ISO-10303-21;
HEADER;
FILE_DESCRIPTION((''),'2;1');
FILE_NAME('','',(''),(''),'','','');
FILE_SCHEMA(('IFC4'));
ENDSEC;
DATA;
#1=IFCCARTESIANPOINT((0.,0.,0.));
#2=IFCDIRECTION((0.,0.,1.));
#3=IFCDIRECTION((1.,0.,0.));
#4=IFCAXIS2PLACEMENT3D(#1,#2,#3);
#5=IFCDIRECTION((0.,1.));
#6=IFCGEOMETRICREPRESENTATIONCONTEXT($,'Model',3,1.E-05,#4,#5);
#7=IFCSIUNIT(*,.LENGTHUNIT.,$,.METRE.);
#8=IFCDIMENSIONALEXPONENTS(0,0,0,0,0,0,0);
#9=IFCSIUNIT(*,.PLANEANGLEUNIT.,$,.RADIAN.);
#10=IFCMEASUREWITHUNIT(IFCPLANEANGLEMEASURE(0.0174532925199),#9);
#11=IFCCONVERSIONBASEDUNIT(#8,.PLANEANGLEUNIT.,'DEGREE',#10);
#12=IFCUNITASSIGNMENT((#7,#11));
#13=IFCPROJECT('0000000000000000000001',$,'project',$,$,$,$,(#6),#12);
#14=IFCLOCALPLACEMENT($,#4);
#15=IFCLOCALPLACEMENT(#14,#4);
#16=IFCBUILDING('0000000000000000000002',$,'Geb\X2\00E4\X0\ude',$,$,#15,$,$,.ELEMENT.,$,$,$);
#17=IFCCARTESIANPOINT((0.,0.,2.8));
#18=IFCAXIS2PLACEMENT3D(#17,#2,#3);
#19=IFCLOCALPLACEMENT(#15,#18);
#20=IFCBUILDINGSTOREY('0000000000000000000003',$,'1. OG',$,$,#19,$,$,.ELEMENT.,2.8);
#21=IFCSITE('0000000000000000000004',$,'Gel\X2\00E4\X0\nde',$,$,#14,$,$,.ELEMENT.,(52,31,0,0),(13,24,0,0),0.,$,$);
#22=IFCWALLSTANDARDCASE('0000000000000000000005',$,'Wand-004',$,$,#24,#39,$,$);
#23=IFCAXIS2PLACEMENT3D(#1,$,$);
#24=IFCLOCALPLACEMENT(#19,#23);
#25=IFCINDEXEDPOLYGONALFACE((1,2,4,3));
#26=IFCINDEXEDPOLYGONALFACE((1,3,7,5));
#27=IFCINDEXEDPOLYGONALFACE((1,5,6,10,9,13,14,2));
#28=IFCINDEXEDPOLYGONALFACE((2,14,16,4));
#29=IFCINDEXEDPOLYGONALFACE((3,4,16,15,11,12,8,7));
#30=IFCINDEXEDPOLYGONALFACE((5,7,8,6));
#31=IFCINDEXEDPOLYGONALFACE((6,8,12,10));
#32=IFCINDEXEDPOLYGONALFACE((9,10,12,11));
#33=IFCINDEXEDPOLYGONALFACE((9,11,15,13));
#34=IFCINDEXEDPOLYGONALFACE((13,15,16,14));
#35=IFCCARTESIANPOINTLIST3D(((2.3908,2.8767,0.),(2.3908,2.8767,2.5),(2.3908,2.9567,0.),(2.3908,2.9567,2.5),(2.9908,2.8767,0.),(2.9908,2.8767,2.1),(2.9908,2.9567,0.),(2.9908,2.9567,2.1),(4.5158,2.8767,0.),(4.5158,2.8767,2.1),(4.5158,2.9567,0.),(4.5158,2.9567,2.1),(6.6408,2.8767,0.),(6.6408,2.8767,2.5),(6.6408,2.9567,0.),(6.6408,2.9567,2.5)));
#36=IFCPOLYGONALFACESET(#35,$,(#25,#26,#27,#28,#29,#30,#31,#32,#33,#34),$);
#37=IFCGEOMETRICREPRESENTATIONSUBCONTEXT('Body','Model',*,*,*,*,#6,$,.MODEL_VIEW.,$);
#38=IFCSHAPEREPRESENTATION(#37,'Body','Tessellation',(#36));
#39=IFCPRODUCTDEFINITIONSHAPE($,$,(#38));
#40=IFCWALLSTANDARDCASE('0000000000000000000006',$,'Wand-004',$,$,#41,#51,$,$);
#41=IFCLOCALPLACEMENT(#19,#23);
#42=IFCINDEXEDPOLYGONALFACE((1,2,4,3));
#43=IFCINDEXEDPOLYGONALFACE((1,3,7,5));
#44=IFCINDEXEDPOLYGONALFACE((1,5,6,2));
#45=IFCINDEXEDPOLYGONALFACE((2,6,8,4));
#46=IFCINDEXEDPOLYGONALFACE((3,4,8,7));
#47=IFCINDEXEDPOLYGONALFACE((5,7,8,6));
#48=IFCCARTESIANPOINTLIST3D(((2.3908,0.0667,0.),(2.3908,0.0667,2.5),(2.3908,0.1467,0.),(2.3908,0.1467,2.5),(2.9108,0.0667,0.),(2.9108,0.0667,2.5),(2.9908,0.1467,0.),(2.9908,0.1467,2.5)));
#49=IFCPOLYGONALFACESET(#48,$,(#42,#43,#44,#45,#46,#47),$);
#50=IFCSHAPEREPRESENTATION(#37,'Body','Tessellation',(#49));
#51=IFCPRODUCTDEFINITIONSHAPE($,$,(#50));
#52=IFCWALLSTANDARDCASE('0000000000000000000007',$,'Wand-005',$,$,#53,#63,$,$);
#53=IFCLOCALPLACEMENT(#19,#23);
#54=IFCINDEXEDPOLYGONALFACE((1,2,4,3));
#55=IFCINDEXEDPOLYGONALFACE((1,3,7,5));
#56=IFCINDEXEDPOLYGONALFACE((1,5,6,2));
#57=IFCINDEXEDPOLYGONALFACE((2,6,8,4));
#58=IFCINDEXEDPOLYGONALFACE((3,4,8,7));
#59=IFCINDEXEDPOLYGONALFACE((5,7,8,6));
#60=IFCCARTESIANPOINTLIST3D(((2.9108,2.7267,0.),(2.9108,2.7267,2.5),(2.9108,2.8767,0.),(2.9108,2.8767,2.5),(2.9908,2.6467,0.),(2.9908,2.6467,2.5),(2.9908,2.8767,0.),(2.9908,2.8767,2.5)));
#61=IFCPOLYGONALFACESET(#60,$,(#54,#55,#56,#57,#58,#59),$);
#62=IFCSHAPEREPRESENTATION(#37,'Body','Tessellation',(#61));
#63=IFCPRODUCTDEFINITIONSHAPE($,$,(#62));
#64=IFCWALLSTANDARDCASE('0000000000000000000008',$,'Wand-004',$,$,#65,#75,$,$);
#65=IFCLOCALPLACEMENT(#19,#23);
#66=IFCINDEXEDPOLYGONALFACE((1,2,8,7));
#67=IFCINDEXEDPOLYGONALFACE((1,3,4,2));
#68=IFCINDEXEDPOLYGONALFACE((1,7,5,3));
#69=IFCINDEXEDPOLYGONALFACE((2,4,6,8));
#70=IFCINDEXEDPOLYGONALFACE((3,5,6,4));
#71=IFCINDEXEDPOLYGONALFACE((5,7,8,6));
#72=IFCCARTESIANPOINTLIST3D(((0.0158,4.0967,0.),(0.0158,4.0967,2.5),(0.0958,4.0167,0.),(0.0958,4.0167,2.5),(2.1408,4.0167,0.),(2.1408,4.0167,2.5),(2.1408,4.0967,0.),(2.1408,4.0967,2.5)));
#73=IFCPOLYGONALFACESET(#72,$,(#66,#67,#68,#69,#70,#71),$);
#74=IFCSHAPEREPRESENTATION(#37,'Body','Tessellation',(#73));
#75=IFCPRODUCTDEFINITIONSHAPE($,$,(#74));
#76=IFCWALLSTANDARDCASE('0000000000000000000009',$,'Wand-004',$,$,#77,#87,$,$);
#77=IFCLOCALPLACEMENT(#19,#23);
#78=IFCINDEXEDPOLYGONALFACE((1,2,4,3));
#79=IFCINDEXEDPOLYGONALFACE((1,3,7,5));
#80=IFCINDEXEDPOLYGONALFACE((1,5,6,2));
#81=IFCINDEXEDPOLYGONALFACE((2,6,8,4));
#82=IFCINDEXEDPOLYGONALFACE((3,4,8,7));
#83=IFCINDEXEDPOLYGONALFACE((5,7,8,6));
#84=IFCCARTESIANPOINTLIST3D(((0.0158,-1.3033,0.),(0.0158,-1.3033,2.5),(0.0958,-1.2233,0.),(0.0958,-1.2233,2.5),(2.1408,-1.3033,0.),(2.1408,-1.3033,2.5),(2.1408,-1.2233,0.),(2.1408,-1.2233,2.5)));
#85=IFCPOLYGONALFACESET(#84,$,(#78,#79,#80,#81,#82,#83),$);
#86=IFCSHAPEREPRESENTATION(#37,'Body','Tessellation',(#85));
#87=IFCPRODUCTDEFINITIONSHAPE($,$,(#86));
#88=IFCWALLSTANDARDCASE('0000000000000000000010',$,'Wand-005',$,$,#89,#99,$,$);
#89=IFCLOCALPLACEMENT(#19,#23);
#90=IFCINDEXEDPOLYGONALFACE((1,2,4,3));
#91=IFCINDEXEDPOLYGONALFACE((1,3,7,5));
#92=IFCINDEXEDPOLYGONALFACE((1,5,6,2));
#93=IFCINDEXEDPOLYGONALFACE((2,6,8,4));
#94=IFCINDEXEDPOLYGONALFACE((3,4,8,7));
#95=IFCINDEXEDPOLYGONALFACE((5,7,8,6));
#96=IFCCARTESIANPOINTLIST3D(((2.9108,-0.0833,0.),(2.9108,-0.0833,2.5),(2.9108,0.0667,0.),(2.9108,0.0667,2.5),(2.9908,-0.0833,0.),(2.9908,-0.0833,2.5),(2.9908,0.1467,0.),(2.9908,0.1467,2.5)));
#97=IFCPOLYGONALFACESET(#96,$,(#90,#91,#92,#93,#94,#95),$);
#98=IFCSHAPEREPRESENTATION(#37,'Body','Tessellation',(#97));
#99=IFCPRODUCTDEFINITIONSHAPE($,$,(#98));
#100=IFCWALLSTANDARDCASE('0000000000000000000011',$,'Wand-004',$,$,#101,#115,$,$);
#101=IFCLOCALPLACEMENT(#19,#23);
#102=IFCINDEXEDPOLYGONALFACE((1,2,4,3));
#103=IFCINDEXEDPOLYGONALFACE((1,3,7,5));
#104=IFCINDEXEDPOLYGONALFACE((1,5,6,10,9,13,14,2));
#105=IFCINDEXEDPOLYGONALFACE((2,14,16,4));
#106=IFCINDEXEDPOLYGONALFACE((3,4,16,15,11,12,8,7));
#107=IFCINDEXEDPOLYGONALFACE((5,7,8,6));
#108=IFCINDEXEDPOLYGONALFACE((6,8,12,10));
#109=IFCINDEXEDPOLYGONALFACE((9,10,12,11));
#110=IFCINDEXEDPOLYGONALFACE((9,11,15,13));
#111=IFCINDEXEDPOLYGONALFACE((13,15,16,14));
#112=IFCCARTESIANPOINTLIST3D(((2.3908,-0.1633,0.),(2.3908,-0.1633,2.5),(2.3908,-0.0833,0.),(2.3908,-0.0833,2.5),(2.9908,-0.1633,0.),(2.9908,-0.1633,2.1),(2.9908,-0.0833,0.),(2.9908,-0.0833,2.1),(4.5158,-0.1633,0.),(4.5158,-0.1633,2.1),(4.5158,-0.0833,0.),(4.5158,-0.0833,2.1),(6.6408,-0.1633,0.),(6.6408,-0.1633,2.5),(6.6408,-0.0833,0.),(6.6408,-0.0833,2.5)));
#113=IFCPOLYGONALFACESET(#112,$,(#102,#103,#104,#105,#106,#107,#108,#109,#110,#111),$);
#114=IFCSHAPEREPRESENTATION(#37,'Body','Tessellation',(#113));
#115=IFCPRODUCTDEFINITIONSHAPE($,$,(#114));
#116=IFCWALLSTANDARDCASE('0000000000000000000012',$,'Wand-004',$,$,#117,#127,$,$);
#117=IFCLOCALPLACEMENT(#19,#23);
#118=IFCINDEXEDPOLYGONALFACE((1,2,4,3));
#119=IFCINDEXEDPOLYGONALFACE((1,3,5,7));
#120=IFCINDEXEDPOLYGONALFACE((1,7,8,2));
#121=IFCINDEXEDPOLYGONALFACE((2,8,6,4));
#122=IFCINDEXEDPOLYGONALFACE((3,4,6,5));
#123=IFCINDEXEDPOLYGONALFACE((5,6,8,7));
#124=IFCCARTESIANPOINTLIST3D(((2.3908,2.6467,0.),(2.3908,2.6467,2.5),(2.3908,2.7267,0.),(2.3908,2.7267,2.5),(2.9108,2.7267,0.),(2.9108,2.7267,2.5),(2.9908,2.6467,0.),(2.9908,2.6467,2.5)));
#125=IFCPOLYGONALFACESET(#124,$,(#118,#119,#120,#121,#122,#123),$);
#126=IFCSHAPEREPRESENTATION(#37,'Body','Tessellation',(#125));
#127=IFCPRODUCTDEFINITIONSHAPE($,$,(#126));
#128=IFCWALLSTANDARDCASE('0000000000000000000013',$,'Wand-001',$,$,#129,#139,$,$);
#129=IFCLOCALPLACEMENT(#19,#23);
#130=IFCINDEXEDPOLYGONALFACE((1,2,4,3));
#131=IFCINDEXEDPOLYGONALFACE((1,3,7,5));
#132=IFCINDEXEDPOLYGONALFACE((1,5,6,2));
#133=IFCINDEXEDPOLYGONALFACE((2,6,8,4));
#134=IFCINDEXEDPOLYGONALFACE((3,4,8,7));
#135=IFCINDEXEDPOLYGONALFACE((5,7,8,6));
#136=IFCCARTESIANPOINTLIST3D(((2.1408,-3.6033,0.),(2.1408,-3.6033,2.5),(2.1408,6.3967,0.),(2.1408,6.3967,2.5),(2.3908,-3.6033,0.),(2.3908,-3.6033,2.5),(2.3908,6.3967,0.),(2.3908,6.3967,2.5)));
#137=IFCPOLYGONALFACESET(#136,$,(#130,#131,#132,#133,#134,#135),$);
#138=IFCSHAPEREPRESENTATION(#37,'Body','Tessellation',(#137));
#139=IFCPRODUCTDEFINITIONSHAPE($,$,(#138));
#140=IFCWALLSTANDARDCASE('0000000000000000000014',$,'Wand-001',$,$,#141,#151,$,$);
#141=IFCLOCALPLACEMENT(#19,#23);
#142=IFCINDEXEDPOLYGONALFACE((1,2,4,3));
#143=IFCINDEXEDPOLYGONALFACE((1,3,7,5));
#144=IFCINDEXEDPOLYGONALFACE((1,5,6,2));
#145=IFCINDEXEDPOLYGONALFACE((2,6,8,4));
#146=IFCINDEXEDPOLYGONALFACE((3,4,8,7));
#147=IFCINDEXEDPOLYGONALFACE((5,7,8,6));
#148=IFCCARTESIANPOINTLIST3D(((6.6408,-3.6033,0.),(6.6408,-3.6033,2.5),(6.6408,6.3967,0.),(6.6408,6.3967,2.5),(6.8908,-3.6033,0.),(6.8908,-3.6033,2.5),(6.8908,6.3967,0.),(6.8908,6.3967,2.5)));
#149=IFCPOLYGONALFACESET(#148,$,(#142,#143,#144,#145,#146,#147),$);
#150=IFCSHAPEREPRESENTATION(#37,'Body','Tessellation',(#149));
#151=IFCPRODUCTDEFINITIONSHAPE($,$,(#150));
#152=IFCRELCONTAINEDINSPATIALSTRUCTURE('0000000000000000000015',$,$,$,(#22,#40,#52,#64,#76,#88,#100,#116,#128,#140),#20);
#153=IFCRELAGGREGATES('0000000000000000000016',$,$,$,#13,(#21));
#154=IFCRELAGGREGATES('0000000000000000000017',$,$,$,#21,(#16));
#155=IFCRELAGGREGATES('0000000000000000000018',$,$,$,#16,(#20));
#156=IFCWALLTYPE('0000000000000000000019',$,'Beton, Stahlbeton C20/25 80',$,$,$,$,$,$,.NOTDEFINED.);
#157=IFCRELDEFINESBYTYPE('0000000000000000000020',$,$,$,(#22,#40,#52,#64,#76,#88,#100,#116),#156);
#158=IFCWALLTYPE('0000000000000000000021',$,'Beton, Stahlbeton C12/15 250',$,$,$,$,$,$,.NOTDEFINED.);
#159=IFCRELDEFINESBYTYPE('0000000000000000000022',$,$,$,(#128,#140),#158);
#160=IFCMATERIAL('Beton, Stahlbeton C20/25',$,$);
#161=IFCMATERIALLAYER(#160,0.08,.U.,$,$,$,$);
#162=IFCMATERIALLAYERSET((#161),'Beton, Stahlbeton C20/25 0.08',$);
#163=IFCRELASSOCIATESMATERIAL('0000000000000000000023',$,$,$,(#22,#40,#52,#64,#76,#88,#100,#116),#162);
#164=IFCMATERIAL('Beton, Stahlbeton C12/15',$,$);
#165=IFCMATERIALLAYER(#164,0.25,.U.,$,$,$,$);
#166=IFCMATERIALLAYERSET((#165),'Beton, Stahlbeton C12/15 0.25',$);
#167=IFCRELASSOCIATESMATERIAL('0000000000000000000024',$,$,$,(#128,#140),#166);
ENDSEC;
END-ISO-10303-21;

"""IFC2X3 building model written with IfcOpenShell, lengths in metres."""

from ifc_helpers import new_model, entity, si_unit, converted_unit, direction, frame, origin_with_axes, origin_2d_with_axis, place, context, subcontext, project, spatial, polyline, rectangle, outline, extrude, material, layer, layer_set, layer_usage, type_object, element, save


model = new_model("IFC2X3")

# Units and contexts
model_context = context("Model", 3, precision=1e-05, world=origin_with_axes(), true_north=direction((0.0, 1.0)))
body_context = subcontext(model_context, "Body", "Model", "MODEL_VIEW")
ifc_project = project(units=[si_unit("LENGTHUNIT", "METRE"), converted_unit("PLANEANGLEUNIT", "DEGREE", entity("IfcPlaneAngleMeasure", 0.0174532925199), si_unit("PLANEANGLEUNIT", "RADIAN"), dimensions=[0, 0, 0, 0, 0, 0, 0])], contexts=[model_context])

# Site, building, storey
site_placement = place(None, origin_with_axes())
site = spatial("IfcSite", under=ifc_project, at=site_placement, Name="Gelände", CompositionType="ELEMENT", RefLatitude=(52, 31, 0, 0), RefLongitude=(13, 24, 0, 0), RefElevation=0.0)
building_placement = place(site_placement, origin_with_axes())
building = spatial("IfcBuilding", under=site, at=building_placement, Name="Gebäude", CompositionType="ELEMENT")
storey_placement = place(building_placement, frame((0.0, 0.0, 2.8), z_axis=(0.0, 0.0, 1.0), x_axis=(1.0, 0.0, 0.0)))
storey = spatial("IfcBuildingStorey", under=building, at=storey_placement, Name="1. OG", CompositionType="ELEMENT", Elevation=2.8)

# Wall, opening
ifc_material_1 = material(Name="Beton, Stahlbeton C20/25")
ifc_layer_1 = layer(ifc_material_1, 0.08, ventilated="UNKNOWN")
ifc_layer_set_1 = layer_set([ifc_layer_1], Name="Beton, Stahlbeton C20/25 0.08")
ifc_layer_usage_1 = layer_usage(ifc_layer_set_1, "AXIS2", "POSITIVE", 0.0)
wall_type_1 = type_object("IfcWallType", Name="Beton, Stahlbeton C20/25 80", PredefinedType="NOTDEFINED")
wall_1_placement = place(storey_placement, frame((6.6408, 2.9567, 0.0), z_axis=(0.0, 0.0, 1.0), x_axis=(-1.0, 0.0, 0.0)))
wall_1 = element("IfcWallStandardCase", 1, at=wall_1_placement, inside=storey, type_object=wall_type_1, material=ifc_layer_usage_1, Name="Wand-004", context=body_context, shape_type="SweptSolid", body=[
    extrude(outline(polyline([(0.0, 0.0), (4.25, 0.0), (4.25, 0.08), (0.0, 0.08), (0.0, 0.0)])), origin_with_axes(), (0.0, 0.0, 1.0), 2.5),
])
opening_1_placement = place(wall_1_placement, frame((2.8875, 0.0, 0.0), z_axis=(0.0, 0.0, 1.0), x_axis=(1.0, 0.0, 0.0)))
element("IfcOpeningElement", 2, at=opening_1_placement, cuts=wall_1, context=body_context, shape_type="SweptSolid", body=[
    extrude(rectangle(XDim=1.525, YDim=2.1, at=origin_2d_with_axis()), frame((0.0, 0.16, 1.05), z_axis=(0.0, -1.0, 0.0), x_axis=(1.0, 0.0, 0.0)), (0.0, 0.0, 1.0), 0.08),
    extrude(rectangle(XDim=1.525, YDim=2.1, at=origin_2d_with_axis()), frame((0.0, 0.0, 1.05), z_axis=(0.0, 1.0, 0.0), x_axis=(1.0, 0.0, 0.0)), (0.0, 0.0, 1.0), 0.08),
])

# Walls
ifc_layer_usage_2 = layer_usage(ifc_layer_set_1, "AXIS2", "NEGATIVE", 0.0)
wall_2_placement = place(storey_placement, frame((2.9908, 0.0667, 0.0), z_axis=(0.0, 0.0, 1.0), x_axis=(-1.0, 0.0, 0.0)))
element("IfcWallStandardCase", 3, at=wall_2_placement, inside=storey, type_object=wall_type_1, material=ifc_layer_usage_2, Name="Wand-004", context=body_context, shape_type="SweptSolid", body=[
    extrude(outline(polyline([(0.0, -0.08), (0.6, -0.08), (0.6, 0.0), (0.08, 0.0), (0.0, -0.08)])), origin_with_axes(), (0.0, 0.0, 1.0), 2.5),
])
ifc_layer_usage_3 = layer_usage(ifc_layer_set_1, "AXIS2", "NEGATIVE", 0.0)
wall_3_placement = place(storey_placement, frame((2.9908, 2.9567, 0.0), z_axis=(0.0, 0.0, 1.0), x_axis=(0.0, -1.0, 0.0)))
element("IfcWallStandardCase", 4, at=wall_3_placement, inside=storey, type_object=wall_type_1, material=ifc_layer_usage_3, Name="Wand-005", context=body_context, shape_type="SweptSolid", body=[
    extrude(outline(polyline([(0.08, -0.08), (0.23, -0.08), (0.31, 0.0), (0.08, 0.0), (0.08, -0.08)])), origin_with_axes(), (0.0, 0.0, 1.0), 2.5),
])
ifc_layer_usage_4 = layer_usage(ifc_layer_set_1, "AXIS2", "POSITIVE", 0.0)
wall_4_placement = place(storey_placement, frame((2.1408, 4.0967, 0.0), z_axis=(0.0, 0.0, 1.0), x_axis=(-1.0, 0.0, 0.0)))
element("IfcWallStandardCase", 5, at=wall_4_placement, inside=storey, type_object=wall_type_1, material=ifc_layer_usage_4, Name="Wand-004", context=body_context, shape_type="SweptSolid", body=[
    extrude(outline(polyline([(0.0, 0.0), (2.125, 0.0), (2.045, 0.08), (0.0, 0.08), (0.0, 0.0)])), origin_with_axes(), (0.0, 0.0, 1.0), 2.5),
])
ifc_layer_usage_5 = layer_usage(ifc_layer_set_1, "AXIS2", "NEGATIVE", 0.0)
wall_5_placement = place(storey_placement, frame((2.1408, -1.3033, 0.0), z_axis=(0.0, 0.0, 1.0), x_axis=(-1.0, 0.0, 0.0)))
element("IfcWallStandardCase", 6, at=wall_5_placement, inside=storey, type_object=wall_type_1, material=ifc_layer_usage_5, Name="Wand-004", context=body_context, shape_type="SweptSolid", body=[
    extrude(outline(polyline([(0.0, -0.08), (2.045, -0.08), (2.125, 0.0), (0.0, 0.0), (0.0, -0.08)])), origin_with_axes(), (0.0, 0.0, 1.0), 2.5),
])
ifc_layer_usage_6 = layer_usage(ifc_layer_set_1, "AXIS2", "POSITIVE", 0.0)
wall_6_placement = place(storey_placement, frame((2.9908, -0.1633, 0.0), z_axis=(0.0, 0.0, 1.0), x_axis=(0.0, 1.0, 0.0)))
element("IfcWallStandardCase", 7, at=wall_6_placement, inside=storey, type_object=wall_type_1, material=ifc_layer_usage_6, Name="Wand-005", context=body_context, shape_type="SweptSolid", body=[
    extrude(outline(polyline([(0.08, 0.0), (0.31, 0.0), (0.23, 0.08), (0.08, 0.08), (0.08, 0.0)])), origin_with_axes(), (0.0, 0.0, 1.0), 2.5),
])

# Wall, opening
ifc_layer_usage_7 = layer_usage(ifc_layer_set_1, "AXIS2", "NEGATIVE", 0.0)
wall_7_placement = place(storey_placement, frame((6.6408, -0.1633, 0.0), z_axis=(0.0, 0.0, 1.0), x_axis=(-1.0, 0.0, 0.0)))
wall_7 = element("IfcWallStandardCase", 8, at=wall_7_placement, inside=storey, type_object=wall_type_1, material=ifc_layer_usage_7, Name="Wand-004", context=body_context, shape_type="SweptSolid", body=[
    extrude(outline(polyline([(0.0, -0.08), (4.25, -0.08), (4.25, 0.0), (0.0, 0.0), (0.0, -0.08)])), origin_with_axes(), (0.0, 0.0, 1.0), 2.5),
])
opening_2_placement = place(wall_7_placement, frame((2.8875, 0.0, 0.0), z_axis=(0.0, 0.0, 1.0), x_axis=(1.0, 0.0, 0.0)))
element("IfcOpeningElement", 9, at=opening_2_placement, cuts=wall_7, context=body_context, shape_type="SweptSolid", body=[
    extrude(rectangle(XDim=1.525, YDim=2.1, at=origin_2d_with_axis()), frame((0.0, -0.16, 1.05), z_axis=(0.0, 1.0, 0.0), x_axis=(1.0, 0.0, 0.0)), (0.0, 0.0, 1.0), 0.08),
    extrude(rectangle(XDim=1.525, YDim=2.1, at=origin_2d_with_axis()), frame((0.0, 0.0, 1.05), z_axis=(0.0, -1.0, 0.0), x_axis=(1.0, 0.0, 0.0)), (0.0, 0.0, 1.0), 0.08),
])

# Wall
ifc_layer_usage_8 = layer_usage(ifc_layer_set_1, "AXIS2", "POSITIVE", 0.0)
wall_8_placement = place(storey_placement, frame((2.9908, 2.7267, 0.0), z_axis=(0.0, 0.0, 1.0), x_axis=(-1.0, 0.0, 0.0)))
element("IfcWallStandardCase", 10, at=wall_8_placement, inside=storey, type_object=wall_type_1, material=ifc_layer_usage_8, Name="Wand-004", context=body_context, shape_type="SweptSolid", body=[
    extrude(outline(polyline([(0.08, 0.0), (0.6, 0.0), (0.6, 0.08), (0.0, 0.08), (0.08, 0.0)])), origin_with_axes(), (0.0, 0.0, 1.0), 2.5),
])

# Walls
ifc_material_2 = material(Name="Beton, Stahlbeton C12/15")
ifc_layer_2 = layer(ifc_material_2, 0.25, ventilated="UNKNOWN")
ifc_layer_set_2 = layer_set([ifc_layer_2], Name="Beton, Stahlbeton C12/15 0.25")
ifc_layer_usage_9 = layer_usage(ifc_layer_set_2, "AXIS2", "POSITIVE", 0.0)
wall_type_2 = type_object("IfcWallType", Name="Beton, Stahlbeton C12/15 250", PredefinedType="NOTDEFINED")
wall_9_placement = place(storey_placement, frame((2.3908, -3.6033, 0.0), z_axis=(0.0, 0.0, 1.0), x_axis=(0.0, 1.0, 0.0)))
element("IfcWallStandardCase", 11, at=wall_9_placement, inside=storey, type_object=wall_type_2, material=ifc_layer_usage_9, Name="Wand-001", context=body_context, shape_type="SweptSolid", body=[
    extrude(outline(polyline([(0.0, 0.0), (10.0, 0.0), (10.0, 0.25), (0.0, 0.25), (0.0, 0.0)])), origin_with_axes(), (0.0, 0.0, 1.0), 2.5),
])
ifc_layer_usage_10 = layer_usage(ifc_layer_set_2, "AXIS2", "POSITIVE", 0.0)
wall_10_placement = place(storey_placement, frame((6.8908, -3.6033, 0.0), z_axis=(0.0, 0.0, 1.0), x_axis=(0.0, 1.0, 0.0)))
element("IfcWallStandardCase", 12, at=wall_10_placement, inside=storey, type_object=wall_type_2, material=ifc_layer_usage_10, Name="Wand-001", context=body_context, shape_type="SweptSolid", body=[
    extrude(outline(polyline([(0.0, 0.0), (10.0, 0.0), (10.0, 0.25), (0.0, 0.25), (0.0, 0.0)])), origin_with_axes(), (0.0, 0.0, 1.0), 2.5),
])

save(model, "model.ifc")
